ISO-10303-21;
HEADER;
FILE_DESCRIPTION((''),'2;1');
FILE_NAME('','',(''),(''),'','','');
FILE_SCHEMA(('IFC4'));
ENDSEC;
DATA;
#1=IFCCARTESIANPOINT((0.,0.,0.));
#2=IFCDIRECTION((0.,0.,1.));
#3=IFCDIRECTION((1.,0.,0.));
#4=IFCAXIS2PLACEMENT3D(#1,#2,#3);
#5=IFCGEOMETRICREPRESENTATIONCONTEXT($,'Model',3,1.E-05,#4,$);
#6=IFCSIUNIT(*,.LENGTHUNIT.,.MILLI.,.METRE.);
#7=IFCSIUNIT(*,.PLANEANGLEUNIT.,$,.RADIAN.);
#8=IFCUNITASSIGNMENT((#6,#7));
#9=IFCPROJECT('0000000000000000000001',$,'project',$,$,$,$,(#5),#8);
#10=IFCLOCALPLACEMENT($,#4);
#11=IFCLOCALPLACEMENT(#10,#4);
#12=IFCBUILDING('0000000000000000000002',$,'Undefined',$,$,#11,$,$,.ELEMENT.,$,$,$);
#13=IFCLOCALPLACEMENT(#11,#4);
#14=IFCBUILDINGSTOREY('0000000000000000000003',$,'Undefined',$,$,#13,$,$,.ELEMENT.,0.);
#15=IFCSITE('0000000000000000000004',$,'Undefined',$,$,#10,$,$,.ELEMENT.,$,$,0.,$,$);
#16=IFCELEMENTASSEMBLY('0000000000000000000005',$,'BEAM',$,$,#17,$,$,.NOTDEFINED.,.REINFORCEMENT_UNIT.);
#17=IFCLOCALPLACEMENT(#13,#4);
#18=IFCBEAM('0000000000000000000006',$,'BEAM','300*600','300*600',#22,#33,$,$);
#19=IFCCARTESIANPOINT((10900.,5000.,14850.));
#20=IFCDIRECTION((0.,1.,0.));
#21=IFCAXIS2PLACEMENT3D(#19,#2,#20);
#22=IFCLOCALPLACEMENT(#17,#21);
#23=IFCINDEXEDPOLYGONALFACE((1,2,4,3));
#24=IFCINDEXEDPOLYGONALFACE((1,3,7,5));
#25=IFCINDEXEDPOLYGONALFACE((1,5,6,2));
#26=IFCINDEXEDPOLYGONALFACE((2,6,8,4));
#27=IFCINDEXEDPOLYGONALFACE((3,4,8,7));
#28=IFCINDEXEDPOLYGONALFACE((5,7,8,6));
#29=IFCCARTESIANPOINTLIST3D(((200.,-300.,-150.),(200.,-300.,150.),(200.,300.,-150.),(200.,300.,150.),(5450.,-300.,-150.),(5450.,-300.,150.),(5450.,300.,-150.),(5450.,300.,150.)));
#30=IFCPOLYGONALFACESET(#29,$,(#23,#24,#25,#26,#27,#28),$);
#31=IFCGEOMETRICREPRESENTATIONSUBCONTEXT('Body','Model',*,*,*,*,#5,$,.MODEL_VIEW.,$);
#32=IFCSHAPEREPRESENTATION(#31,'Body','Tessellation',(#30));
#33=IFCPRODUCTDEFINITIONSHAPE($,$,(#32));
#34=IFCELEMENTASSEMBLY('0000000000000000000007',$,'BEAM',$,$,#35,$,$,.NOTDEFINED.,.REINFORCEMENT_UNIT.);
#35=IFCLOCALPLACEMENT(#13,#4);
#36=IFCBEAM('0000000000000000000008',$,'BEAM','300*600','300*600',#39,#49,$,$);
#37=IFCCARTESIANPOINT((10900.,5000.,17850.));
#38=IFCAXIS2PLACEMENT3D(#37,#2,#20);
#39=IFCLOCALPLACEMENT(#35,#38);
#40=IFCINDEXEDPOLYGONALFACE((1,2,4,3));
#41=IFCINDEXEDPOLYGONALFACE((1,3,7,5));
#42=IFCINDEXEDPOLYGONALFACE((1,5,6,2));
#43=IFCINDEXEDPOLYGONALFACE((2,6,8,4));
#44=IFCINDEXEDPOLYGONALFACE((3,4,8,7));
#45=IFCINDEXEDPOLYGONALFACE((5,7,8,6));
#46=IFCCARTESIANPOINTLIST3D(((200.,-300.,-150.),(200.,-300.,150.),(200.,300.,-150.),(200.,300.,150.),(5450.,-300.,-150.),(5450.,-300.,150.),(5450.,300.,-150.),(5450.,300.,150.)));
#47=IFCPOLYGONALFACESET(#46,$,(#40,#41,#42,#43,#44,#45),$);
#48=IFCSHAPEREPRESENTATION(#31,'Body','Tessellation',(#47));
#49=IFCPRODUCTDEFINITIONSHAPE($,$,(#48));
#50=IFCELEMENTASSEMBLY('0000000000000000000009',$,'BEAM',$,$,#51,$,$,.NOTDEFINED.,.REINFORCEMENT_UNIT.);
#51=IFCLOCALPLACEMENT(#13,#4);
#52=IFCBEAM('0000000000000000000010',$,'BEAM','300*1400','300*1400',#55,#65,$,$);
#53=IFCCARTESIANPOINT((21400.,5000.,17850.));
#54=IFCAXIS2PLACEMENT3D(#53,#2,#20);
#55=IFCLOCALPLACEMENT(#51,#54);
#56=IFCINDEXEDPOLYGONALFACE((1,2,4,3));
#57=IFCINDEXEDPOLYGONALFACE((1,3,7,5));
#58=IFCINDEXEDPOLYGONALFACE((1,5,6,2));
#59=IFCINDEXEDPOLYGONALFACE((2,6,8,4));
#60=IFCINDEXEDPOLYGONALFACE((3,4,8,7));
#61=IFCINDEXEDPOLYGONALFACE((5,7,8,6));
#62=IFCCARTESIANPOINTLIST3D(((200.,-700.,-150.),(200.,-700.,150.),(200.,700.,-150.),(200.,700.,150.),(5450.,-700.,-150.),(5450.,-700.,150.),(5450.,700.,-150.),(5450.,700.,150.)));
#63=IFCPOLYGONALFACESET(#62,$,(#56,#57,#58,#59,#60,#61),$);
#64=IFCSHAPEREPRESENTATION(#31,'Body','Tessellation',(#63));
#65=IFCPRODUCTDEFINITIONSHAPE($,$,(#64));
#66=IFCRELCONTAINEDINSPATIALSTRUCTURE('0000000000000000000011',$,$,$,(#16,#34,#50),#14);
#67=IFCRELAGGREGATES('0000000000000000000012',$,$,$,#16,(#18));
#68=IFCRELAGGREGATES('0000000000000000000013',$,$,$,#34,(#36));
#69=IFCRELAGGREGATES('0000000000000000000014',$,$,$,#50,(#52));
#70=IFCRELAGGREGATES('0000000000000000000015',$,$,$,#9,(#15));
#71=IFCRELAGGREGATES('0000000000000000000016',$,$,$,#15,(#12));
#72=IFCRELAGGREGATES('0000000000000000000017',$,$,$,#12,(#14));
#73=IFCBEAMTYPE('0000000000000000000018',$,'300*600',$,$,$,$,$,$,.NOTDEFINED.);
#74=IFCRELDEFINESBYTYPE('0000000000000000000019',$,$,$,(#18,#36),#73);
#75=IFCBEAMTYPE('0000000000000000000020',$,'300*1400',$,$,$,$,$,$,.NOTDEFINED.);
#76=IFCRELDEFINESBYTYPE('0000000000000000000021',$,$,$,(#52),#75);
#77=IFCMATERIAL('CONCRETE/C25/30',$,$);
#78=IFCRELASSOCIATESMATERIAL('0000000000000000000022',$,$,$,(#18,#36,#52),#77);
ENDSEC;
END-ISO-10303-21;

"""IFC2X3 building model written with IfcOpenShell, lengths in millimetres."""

from ifc_helpers import new_model, si_unit, frame, origin_with_axes, origin_2d_with_axis, place, context, subcontext, project, spatial, rectangle, extrude, material, type_object, element, aggregate, save


model = new_model("IFC2X3")

# Units and contexts
model_context = context("Model", 3, precision=1e-05, world=origin_with_axes())
body_context = subcontext(model_context, "Body", "Model", "MODEL_VIEW")
ifc_project = project(units=[si_unit("LENGTHUNIT", "METRE", prefix="MILLI"), si_unit("PLANEANGLEUNIT", "RADIAN")], contexts=[model_context])

# Site, building, storey
site_placement = place(None, origin_with_axes())
site = spatial("IfcSite", under=ifc_project, at=site_placement, Name="Undefined", CompositionType="ELEMENT", RefElevation=0.0)
building_placement = place(site_placement, origin_with_axes())
building = spatial("IfcBuilding", under=site, at=building_placement, Name="Undefined", CompositionType="ELEMENT")
storey_placement = place(building_placement, origin_with_axes())
storey = spatial("IfcBuildingStorey", under=building, at=storey_placement, Name="Undefined", CompositionType="ELEMENT", Elevation=0.0)

# Shared definitions
ifc_material = material(Name="CONCRETE/C25/30")

# Element assemblies, beams
beam_type_1 = type_object("IfcBeamType", Name="300*600", PredefinedType="NOTDEFINED")
assembly_1_placement = place(storey_placement, origin_with_axes())
assembly_1 = element("IfcElementAssembly", 1, at=assembly_1_placement, inside=storey, Name="BEAM", AssemblyPlace="NOTDEFINED", PredefinedType="REINFORCEMENT_UNIT")
beam_1_placement = place(assembly_1_placement, frame((10900.0, 5000.0, 14850.0), z_axis=(0.0, 0.0, 1.0), x_axis=(0.0, 1.0, 0.0)))
beam_1 = element("IfcBeam", 2, at=beam_1_placement, type_object=beam_type_1, material=ifc_material, Name="BEAM", Description="300*600", ObjectType="300*600", context=body_context, shape_type="SweptSolid", body=[
    extrude(rectangle(XDim=600.0, YDim=300.0, at=origin_2d_with_axis()), frame((5450.0, 0.0, 0.0), z_axis=(-1.0, 0.0, 0.0), x_axis=(0.0, -1.0, 0.0)), (0.0, 0.0, 1.0), 5250.0),
])
aggregate(assembly_1, [beam_1])
assembly_2_placement = place(storey_placement, origin_with_axes())
assembly_2 = element("IfcElementAssembly", 3, at=assembly_2_placement, inside=storey, Name="BEAM", AssemblyPlace="NOTDEFINED", PredefinedType="REINFORCEMENT_UNIT")
beam_2_placement = place(assembly_2_placement, frame((10900.0, 5000.0, 17850.0), z_axis=(0.0, 0.0, 1.0), x_axis=(0.0, 1.0, 0.0)))
beam_2 = element("IfcBeam", 4, at=beam_2_placement, type_object=beam_type_1, material=ifc_material, Name="BEAM", Description="300*600", ObjectType="300*600", context=body_context, shape_type="SweptSolid", body=[
    extrude(rectangle(XDim=600.0, YDim=300.0, at=origin_2d_with_axis()), frame((5450.0, 0.0, 0.0), z_axis=(-1.0, 0.0, 0.0), x_axis=(0.0, -1.0, 0.0)), (0.0, 0.0, 1.0), 5250.0),
])
aggregate(assembly_2, [beam_2])
assembly_3_placement = place(storey_placement, origin_with_axes())
assembly_3 = element("IfcElementAssembly", 5, at=assembly_3_placement, inside=storey, Name="BEAM", AssemblyPlace="NOTDEFINED", PredefinedType="REINFORCEMENT_UNIT")
beam_type_2 = type_object("IfcBeamType", Name="300*1400", PredefinedType="NOTDEFINED")
beam_3_placement = place(assembly_3_placement, frame((21400.0, 5000.0, 17850.0), z_axis=(0.0, 0.0, 1.0), x_axis=(0.0, 1.0, 0.0)))
beam_3 = element("IfcBeam", 6, at=beam_3_placement, type_object=beam_type_2, material=ifc_material, Name="BEAM", Description="300*1400", ObjectType="300*1400", context=body_context, shape_type="SweptSolid", body=[
    extrude(rectangle(XDim=1400.0, YDim=300.0, at=origin_2d_with_axis()), frame((5450.0, 0.0, 0.0), z_axis=(-1.0, 0.0, 0.0), x_axis=(0.0, -1.0, 0.0)), (0.0, 0.0, 1.0), 5250.0),
])
aggregate(assembly_3, [beam_3])

save(model, "model.ifc")
